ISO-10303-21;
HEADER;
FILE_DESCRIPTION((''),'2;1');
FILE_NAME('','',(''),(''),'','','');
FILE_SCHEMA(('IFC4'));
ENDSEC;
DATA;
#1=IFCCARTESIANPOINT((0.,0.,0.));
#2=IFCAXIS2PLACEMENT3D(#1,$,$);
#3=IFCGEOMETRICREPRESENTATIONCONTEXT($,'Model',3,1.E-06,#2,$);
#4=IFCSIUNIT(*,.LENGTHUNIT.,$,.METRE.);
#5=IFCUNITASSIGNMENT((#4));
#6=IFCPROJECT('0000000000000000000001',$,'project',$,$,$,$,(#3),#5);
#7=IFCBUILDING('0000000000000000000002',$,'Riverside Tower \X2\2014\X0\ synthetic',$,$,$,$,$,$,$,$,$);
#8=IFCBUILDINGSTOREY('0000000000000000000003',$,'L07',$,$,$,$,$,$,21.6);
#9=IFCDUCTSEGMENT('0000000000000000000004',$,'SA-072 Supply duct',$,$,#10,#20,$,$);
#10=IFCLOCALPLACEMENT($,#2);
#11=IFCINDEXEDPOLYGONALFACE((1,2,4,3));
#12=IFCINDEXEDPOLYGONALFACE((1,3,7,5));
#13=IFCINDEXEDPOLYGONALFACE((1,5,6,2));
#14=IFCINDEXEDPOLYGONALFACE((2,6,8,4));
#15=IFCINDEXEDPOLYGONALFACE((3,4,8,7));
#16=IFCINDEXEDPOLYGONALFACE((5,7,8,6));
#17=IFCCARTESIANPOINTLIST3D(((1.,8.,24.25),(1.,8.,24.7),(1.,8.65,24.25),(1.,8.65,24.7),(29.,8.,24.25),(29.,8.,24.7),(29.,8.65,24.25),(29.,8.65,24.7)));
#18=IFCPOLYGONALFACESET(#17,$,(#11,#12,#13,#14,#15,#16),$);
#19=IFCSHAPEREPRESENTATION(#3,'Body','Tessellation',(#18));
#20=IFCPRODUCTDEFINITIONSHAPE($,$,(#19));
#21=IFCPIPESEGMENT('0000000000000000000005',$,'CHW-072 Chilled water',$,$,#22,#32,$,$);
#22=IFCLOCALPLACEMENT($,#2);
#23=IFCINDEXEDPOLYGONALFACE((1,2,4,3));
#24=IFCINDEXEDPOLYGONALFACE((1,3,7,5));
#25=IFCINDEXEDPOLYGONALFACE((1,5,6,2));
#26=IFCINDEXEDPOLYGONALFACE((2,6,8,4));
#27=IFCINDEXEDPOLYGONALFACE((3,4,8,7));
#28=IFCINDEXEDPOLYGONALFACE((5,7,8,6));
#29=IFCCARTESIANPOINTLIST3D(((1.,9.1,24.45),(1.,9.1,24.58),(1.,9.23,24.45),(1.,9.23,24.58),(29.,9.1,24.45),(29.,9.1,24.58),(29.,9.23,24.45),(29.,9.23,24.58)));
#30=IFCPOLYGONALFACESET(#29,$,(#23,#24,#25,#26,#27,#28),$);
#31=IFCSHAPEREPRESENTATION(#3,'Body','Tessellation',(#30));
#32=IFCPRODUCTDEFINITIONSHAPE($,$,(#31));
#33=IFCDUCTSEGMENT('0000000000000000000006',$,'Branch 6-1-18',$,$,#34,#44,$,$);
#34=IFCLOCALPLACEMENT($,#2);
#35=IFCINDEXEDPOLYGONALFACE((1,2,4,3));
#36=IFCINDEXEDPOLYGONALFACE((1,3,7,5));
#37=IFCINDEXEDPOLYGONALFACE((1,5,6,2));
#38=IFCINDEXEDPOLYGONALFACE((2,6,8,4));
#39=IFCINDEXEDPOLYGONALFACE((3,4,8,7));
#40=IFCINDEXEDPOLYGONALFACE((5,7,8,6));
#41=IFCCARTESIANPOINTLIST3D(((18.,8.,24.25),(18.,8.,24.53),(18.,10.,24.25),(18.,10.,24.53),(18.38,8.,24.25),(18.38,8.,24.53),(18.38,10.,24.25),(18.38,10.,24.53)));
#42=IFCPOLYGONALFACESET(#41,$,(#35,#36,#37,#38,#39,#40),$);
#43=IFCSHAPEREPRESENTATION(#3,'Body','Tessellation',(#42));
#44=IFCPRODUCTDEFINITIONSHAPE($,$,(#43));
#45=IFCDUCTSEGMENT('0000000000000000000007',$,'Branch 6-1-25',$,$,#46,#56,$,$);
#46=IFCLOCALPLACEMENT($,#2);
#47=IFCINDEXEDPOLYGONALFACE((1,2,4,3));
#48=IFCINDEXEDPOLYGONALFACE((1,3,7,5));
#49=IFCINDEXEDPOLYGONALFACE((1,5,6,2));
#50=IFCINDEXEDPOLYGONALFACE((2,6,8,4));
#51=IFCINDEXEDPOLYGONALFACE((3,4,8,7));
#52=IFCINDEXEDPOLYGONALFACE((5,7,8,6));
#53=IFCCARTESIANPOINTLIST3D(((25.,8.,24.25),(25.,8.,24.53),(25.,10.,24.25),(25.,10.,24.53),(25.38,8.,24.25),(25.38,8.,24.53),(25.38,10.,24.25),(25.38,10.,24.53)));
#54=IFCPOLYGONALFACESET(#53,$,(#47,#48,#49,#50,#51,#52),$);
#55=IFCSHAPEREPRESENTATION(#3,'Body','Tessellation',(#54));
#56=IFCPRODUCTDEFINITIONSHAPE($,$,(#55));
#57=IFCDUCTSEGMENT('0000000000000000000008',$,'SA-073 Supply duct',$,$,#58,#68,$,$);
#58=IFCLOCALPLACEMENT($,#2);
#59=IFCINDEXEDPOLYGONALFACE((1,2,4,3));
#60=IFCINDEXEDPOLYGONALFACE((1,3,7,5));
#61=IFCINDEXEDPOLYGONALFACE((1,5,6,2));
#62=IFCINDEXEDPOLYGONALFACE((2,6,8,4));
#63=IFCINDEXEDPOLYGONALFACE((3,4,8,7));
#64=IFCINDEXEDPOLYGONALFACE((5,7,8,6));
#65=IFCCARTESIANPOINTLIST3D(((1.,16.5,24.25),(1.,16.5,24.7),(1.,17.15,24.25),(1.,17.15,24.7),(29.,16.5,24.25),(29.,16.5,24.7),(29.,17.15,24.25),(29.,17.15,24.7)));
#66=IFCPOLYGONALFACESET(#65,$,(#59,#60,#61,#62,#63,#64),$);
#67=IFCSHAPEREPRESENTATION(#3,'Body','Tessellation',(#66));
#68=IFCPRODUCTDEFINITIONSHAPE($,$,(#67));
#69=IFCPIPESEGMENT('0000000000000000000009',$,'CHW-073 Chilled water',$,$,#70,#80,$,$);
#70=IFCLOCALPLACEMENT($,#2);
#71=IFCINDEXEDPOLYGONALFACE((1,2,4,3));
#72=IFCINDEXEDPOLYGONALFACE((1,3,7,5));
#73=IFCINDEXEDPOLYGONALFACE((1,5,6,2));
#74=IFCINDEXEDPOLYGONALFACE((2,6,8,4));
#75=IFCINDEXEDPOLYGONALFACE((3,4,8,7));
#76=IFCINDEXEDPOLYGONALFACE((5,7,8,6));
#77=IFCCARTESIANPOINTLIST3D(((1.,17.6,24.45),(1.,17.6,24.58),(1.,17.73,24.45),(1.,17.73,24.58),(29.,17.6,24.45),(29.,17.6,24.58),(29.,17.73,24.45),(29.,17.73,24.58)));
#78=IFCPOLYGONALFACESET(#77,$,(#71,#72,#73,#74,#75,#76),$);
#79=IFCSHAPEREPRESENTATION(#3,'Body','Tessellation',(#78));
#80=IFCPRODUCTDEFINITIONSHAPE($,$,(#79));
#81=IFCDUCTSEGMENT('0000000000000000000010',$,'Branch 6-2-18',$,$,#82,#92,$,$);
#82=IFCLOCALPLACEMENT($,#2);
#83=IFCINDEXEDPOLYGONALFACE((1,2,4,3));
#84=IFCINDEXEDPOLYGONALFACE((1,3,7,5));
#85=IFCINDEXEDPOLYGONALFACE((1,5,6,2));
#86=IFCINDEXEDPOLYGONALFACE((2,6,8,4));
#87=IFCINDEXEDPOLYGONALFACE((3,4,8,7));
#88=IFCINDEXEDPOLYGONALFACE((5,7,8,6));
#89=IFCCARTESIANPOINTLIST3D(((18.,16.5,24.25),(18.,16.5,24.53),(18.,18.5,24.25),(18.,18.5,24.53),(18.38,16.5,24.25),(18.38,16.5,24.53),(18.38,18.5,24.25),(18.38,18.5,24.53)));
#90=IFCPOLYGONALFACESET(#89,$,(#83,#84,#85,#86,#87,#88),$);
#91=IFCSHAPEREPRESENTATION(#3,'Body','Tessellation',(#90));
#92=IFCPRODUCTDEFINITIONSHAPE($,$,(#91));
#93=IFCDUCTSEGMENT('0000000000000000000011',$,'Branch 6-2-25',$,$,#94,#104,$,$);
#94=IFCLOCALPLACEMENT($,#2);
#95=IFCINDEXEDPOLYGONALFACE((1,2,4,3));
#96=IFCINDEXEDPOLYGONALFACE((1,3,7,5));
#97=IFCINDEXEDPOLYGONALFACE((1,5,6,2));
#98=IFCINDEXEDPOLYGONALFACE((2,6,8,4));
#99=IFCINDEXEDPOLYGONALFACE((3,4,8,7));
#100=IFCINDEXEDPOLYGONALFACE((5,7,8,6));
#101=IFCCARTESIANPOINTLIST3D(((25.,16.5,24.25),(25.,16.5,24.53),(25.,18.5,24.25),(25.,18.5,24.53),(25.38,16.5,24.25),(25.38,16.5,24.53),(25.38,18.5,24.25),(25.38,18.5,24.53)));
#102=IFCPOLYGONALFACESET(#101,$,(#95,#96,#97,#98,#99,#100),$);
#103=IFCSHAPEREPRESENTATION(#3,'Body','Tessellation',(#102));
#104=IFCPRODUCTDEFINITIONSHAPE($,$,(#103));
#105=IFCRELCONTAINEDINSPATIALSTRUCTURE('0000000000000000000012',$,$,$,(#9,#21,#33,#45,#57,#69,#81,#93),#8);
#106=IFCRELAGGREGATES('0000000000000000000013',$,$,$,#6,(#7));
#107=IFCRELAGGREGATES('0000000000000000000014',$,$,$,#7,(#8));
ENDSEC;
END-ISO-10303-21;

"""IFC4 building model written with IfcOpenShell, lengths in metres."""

from ifc_helpers import new_model, si_unit, frame, origin, place, context, project, spatial, rectangle, extrude, element, save


model = new_model("IFC4")

# Units and contexts
model_context = context("Model", 3, precision=1e-06, world=origin())
ifc_project = project(units=[si_unit("LENGTHUNIT", "METRE")], contexts=[model_context])

# Building, storey
building = spatial("IfcBuilding", under=ifc_project, Name="Riverside Tower — synthetic")
storey = spatial("IfcBuildingStorey", under=building, Name="L07", Elevation=21.6)

# Duct segment
duct_segment_1_placement = place(None, frame((15.0, 8.325, 24.25)))
element("IfcDuctSegment", 1, at=duct_segment_1_placement, inside=storey, Name="SA-072 Supply duct", context=model_context, shape_type="SweptSolid", body=[
    extrude(rectangle(XDim=28.0, YDim=0.65), origin(), (0.0, 0.0, 1.0), 0.45),
])

# Pipe segment
pipe_segment_1_placement = place(None, frame((15.0, 9.165, 24.45)))
element("IfcPipeSegment", 2, at=pipe_segment_1_placement, inside=storey, Name="CHW-072 Chilled water", context=model_context, shape_type="SweptSolid", body=[
    extrude(rectangle(XDim=28.0, YDim=0.13), origin(), (0.0, 0.0, 1.0), 0.13),
])

# Duct segments
for number, where, name in (
    (3, (18.19, 9.0, 24.25), "Branch 6-1-18"),
    (4, (25.19, 9.0, 24.25), "Branch 6-1-25"),
):
    element("IfcDuctSegment", number, at=place(None, frame(where)), inside=storey, Name=name, context=model_context, shape_type="SweptSolid", body=[
        extrude(rectangle(XDim=0.38, YDim=2.0), origin(), (0.0, 0.0, 1.0), 0.28),
    ])
duct_segment_2_placement = place(None, frame((15.0, 16.825, 24.25)))
element("IfcDuctSegment", 5, at=duct_segment_2_placement, inside=storey, Name="SA-073 Supply duct", context=model_context, shape_type="SweptSolid", body=[
    extrude(rectangle(XDim=28.0, YDim=0.65), origin(), (0.0, 0.0, 1.0), 0.45),
])

# Pipe segment
pipe_segment_2_placement = place(None, frame((15.0, 17.665, 24.45)))
element("IfcPipeSegment", 6, at=pipe_segment_2_placement, inside=storey, Name="CHW-073 Chilled water", context=model_context, shape_type="SweptSolid", body=[
    extrude(rectangle(XDim=28.0, YDim=0.13), origin(), (0.0, 0.0, 1.0), 0.13),
])

# Duct segments
for number, where, name in (
    (7, (18.19, 17.5, 24.25), "Branch 6-2-18"),
    (8, (25.19, 17.5, 24.25), "Branch 6-2-25"),
):
    element("IfcDuctSegment", number, at=place(None, frame(where)), inside=storey, Name=name, context=model_context, shape_type="SweptSolid", body=[
        extrude(rectangle(XDim=0.38, YDim=2.0), origin(), (0.0, 0.0, 1.0), 0.28),
    ])

save(model, "model.ifc")
